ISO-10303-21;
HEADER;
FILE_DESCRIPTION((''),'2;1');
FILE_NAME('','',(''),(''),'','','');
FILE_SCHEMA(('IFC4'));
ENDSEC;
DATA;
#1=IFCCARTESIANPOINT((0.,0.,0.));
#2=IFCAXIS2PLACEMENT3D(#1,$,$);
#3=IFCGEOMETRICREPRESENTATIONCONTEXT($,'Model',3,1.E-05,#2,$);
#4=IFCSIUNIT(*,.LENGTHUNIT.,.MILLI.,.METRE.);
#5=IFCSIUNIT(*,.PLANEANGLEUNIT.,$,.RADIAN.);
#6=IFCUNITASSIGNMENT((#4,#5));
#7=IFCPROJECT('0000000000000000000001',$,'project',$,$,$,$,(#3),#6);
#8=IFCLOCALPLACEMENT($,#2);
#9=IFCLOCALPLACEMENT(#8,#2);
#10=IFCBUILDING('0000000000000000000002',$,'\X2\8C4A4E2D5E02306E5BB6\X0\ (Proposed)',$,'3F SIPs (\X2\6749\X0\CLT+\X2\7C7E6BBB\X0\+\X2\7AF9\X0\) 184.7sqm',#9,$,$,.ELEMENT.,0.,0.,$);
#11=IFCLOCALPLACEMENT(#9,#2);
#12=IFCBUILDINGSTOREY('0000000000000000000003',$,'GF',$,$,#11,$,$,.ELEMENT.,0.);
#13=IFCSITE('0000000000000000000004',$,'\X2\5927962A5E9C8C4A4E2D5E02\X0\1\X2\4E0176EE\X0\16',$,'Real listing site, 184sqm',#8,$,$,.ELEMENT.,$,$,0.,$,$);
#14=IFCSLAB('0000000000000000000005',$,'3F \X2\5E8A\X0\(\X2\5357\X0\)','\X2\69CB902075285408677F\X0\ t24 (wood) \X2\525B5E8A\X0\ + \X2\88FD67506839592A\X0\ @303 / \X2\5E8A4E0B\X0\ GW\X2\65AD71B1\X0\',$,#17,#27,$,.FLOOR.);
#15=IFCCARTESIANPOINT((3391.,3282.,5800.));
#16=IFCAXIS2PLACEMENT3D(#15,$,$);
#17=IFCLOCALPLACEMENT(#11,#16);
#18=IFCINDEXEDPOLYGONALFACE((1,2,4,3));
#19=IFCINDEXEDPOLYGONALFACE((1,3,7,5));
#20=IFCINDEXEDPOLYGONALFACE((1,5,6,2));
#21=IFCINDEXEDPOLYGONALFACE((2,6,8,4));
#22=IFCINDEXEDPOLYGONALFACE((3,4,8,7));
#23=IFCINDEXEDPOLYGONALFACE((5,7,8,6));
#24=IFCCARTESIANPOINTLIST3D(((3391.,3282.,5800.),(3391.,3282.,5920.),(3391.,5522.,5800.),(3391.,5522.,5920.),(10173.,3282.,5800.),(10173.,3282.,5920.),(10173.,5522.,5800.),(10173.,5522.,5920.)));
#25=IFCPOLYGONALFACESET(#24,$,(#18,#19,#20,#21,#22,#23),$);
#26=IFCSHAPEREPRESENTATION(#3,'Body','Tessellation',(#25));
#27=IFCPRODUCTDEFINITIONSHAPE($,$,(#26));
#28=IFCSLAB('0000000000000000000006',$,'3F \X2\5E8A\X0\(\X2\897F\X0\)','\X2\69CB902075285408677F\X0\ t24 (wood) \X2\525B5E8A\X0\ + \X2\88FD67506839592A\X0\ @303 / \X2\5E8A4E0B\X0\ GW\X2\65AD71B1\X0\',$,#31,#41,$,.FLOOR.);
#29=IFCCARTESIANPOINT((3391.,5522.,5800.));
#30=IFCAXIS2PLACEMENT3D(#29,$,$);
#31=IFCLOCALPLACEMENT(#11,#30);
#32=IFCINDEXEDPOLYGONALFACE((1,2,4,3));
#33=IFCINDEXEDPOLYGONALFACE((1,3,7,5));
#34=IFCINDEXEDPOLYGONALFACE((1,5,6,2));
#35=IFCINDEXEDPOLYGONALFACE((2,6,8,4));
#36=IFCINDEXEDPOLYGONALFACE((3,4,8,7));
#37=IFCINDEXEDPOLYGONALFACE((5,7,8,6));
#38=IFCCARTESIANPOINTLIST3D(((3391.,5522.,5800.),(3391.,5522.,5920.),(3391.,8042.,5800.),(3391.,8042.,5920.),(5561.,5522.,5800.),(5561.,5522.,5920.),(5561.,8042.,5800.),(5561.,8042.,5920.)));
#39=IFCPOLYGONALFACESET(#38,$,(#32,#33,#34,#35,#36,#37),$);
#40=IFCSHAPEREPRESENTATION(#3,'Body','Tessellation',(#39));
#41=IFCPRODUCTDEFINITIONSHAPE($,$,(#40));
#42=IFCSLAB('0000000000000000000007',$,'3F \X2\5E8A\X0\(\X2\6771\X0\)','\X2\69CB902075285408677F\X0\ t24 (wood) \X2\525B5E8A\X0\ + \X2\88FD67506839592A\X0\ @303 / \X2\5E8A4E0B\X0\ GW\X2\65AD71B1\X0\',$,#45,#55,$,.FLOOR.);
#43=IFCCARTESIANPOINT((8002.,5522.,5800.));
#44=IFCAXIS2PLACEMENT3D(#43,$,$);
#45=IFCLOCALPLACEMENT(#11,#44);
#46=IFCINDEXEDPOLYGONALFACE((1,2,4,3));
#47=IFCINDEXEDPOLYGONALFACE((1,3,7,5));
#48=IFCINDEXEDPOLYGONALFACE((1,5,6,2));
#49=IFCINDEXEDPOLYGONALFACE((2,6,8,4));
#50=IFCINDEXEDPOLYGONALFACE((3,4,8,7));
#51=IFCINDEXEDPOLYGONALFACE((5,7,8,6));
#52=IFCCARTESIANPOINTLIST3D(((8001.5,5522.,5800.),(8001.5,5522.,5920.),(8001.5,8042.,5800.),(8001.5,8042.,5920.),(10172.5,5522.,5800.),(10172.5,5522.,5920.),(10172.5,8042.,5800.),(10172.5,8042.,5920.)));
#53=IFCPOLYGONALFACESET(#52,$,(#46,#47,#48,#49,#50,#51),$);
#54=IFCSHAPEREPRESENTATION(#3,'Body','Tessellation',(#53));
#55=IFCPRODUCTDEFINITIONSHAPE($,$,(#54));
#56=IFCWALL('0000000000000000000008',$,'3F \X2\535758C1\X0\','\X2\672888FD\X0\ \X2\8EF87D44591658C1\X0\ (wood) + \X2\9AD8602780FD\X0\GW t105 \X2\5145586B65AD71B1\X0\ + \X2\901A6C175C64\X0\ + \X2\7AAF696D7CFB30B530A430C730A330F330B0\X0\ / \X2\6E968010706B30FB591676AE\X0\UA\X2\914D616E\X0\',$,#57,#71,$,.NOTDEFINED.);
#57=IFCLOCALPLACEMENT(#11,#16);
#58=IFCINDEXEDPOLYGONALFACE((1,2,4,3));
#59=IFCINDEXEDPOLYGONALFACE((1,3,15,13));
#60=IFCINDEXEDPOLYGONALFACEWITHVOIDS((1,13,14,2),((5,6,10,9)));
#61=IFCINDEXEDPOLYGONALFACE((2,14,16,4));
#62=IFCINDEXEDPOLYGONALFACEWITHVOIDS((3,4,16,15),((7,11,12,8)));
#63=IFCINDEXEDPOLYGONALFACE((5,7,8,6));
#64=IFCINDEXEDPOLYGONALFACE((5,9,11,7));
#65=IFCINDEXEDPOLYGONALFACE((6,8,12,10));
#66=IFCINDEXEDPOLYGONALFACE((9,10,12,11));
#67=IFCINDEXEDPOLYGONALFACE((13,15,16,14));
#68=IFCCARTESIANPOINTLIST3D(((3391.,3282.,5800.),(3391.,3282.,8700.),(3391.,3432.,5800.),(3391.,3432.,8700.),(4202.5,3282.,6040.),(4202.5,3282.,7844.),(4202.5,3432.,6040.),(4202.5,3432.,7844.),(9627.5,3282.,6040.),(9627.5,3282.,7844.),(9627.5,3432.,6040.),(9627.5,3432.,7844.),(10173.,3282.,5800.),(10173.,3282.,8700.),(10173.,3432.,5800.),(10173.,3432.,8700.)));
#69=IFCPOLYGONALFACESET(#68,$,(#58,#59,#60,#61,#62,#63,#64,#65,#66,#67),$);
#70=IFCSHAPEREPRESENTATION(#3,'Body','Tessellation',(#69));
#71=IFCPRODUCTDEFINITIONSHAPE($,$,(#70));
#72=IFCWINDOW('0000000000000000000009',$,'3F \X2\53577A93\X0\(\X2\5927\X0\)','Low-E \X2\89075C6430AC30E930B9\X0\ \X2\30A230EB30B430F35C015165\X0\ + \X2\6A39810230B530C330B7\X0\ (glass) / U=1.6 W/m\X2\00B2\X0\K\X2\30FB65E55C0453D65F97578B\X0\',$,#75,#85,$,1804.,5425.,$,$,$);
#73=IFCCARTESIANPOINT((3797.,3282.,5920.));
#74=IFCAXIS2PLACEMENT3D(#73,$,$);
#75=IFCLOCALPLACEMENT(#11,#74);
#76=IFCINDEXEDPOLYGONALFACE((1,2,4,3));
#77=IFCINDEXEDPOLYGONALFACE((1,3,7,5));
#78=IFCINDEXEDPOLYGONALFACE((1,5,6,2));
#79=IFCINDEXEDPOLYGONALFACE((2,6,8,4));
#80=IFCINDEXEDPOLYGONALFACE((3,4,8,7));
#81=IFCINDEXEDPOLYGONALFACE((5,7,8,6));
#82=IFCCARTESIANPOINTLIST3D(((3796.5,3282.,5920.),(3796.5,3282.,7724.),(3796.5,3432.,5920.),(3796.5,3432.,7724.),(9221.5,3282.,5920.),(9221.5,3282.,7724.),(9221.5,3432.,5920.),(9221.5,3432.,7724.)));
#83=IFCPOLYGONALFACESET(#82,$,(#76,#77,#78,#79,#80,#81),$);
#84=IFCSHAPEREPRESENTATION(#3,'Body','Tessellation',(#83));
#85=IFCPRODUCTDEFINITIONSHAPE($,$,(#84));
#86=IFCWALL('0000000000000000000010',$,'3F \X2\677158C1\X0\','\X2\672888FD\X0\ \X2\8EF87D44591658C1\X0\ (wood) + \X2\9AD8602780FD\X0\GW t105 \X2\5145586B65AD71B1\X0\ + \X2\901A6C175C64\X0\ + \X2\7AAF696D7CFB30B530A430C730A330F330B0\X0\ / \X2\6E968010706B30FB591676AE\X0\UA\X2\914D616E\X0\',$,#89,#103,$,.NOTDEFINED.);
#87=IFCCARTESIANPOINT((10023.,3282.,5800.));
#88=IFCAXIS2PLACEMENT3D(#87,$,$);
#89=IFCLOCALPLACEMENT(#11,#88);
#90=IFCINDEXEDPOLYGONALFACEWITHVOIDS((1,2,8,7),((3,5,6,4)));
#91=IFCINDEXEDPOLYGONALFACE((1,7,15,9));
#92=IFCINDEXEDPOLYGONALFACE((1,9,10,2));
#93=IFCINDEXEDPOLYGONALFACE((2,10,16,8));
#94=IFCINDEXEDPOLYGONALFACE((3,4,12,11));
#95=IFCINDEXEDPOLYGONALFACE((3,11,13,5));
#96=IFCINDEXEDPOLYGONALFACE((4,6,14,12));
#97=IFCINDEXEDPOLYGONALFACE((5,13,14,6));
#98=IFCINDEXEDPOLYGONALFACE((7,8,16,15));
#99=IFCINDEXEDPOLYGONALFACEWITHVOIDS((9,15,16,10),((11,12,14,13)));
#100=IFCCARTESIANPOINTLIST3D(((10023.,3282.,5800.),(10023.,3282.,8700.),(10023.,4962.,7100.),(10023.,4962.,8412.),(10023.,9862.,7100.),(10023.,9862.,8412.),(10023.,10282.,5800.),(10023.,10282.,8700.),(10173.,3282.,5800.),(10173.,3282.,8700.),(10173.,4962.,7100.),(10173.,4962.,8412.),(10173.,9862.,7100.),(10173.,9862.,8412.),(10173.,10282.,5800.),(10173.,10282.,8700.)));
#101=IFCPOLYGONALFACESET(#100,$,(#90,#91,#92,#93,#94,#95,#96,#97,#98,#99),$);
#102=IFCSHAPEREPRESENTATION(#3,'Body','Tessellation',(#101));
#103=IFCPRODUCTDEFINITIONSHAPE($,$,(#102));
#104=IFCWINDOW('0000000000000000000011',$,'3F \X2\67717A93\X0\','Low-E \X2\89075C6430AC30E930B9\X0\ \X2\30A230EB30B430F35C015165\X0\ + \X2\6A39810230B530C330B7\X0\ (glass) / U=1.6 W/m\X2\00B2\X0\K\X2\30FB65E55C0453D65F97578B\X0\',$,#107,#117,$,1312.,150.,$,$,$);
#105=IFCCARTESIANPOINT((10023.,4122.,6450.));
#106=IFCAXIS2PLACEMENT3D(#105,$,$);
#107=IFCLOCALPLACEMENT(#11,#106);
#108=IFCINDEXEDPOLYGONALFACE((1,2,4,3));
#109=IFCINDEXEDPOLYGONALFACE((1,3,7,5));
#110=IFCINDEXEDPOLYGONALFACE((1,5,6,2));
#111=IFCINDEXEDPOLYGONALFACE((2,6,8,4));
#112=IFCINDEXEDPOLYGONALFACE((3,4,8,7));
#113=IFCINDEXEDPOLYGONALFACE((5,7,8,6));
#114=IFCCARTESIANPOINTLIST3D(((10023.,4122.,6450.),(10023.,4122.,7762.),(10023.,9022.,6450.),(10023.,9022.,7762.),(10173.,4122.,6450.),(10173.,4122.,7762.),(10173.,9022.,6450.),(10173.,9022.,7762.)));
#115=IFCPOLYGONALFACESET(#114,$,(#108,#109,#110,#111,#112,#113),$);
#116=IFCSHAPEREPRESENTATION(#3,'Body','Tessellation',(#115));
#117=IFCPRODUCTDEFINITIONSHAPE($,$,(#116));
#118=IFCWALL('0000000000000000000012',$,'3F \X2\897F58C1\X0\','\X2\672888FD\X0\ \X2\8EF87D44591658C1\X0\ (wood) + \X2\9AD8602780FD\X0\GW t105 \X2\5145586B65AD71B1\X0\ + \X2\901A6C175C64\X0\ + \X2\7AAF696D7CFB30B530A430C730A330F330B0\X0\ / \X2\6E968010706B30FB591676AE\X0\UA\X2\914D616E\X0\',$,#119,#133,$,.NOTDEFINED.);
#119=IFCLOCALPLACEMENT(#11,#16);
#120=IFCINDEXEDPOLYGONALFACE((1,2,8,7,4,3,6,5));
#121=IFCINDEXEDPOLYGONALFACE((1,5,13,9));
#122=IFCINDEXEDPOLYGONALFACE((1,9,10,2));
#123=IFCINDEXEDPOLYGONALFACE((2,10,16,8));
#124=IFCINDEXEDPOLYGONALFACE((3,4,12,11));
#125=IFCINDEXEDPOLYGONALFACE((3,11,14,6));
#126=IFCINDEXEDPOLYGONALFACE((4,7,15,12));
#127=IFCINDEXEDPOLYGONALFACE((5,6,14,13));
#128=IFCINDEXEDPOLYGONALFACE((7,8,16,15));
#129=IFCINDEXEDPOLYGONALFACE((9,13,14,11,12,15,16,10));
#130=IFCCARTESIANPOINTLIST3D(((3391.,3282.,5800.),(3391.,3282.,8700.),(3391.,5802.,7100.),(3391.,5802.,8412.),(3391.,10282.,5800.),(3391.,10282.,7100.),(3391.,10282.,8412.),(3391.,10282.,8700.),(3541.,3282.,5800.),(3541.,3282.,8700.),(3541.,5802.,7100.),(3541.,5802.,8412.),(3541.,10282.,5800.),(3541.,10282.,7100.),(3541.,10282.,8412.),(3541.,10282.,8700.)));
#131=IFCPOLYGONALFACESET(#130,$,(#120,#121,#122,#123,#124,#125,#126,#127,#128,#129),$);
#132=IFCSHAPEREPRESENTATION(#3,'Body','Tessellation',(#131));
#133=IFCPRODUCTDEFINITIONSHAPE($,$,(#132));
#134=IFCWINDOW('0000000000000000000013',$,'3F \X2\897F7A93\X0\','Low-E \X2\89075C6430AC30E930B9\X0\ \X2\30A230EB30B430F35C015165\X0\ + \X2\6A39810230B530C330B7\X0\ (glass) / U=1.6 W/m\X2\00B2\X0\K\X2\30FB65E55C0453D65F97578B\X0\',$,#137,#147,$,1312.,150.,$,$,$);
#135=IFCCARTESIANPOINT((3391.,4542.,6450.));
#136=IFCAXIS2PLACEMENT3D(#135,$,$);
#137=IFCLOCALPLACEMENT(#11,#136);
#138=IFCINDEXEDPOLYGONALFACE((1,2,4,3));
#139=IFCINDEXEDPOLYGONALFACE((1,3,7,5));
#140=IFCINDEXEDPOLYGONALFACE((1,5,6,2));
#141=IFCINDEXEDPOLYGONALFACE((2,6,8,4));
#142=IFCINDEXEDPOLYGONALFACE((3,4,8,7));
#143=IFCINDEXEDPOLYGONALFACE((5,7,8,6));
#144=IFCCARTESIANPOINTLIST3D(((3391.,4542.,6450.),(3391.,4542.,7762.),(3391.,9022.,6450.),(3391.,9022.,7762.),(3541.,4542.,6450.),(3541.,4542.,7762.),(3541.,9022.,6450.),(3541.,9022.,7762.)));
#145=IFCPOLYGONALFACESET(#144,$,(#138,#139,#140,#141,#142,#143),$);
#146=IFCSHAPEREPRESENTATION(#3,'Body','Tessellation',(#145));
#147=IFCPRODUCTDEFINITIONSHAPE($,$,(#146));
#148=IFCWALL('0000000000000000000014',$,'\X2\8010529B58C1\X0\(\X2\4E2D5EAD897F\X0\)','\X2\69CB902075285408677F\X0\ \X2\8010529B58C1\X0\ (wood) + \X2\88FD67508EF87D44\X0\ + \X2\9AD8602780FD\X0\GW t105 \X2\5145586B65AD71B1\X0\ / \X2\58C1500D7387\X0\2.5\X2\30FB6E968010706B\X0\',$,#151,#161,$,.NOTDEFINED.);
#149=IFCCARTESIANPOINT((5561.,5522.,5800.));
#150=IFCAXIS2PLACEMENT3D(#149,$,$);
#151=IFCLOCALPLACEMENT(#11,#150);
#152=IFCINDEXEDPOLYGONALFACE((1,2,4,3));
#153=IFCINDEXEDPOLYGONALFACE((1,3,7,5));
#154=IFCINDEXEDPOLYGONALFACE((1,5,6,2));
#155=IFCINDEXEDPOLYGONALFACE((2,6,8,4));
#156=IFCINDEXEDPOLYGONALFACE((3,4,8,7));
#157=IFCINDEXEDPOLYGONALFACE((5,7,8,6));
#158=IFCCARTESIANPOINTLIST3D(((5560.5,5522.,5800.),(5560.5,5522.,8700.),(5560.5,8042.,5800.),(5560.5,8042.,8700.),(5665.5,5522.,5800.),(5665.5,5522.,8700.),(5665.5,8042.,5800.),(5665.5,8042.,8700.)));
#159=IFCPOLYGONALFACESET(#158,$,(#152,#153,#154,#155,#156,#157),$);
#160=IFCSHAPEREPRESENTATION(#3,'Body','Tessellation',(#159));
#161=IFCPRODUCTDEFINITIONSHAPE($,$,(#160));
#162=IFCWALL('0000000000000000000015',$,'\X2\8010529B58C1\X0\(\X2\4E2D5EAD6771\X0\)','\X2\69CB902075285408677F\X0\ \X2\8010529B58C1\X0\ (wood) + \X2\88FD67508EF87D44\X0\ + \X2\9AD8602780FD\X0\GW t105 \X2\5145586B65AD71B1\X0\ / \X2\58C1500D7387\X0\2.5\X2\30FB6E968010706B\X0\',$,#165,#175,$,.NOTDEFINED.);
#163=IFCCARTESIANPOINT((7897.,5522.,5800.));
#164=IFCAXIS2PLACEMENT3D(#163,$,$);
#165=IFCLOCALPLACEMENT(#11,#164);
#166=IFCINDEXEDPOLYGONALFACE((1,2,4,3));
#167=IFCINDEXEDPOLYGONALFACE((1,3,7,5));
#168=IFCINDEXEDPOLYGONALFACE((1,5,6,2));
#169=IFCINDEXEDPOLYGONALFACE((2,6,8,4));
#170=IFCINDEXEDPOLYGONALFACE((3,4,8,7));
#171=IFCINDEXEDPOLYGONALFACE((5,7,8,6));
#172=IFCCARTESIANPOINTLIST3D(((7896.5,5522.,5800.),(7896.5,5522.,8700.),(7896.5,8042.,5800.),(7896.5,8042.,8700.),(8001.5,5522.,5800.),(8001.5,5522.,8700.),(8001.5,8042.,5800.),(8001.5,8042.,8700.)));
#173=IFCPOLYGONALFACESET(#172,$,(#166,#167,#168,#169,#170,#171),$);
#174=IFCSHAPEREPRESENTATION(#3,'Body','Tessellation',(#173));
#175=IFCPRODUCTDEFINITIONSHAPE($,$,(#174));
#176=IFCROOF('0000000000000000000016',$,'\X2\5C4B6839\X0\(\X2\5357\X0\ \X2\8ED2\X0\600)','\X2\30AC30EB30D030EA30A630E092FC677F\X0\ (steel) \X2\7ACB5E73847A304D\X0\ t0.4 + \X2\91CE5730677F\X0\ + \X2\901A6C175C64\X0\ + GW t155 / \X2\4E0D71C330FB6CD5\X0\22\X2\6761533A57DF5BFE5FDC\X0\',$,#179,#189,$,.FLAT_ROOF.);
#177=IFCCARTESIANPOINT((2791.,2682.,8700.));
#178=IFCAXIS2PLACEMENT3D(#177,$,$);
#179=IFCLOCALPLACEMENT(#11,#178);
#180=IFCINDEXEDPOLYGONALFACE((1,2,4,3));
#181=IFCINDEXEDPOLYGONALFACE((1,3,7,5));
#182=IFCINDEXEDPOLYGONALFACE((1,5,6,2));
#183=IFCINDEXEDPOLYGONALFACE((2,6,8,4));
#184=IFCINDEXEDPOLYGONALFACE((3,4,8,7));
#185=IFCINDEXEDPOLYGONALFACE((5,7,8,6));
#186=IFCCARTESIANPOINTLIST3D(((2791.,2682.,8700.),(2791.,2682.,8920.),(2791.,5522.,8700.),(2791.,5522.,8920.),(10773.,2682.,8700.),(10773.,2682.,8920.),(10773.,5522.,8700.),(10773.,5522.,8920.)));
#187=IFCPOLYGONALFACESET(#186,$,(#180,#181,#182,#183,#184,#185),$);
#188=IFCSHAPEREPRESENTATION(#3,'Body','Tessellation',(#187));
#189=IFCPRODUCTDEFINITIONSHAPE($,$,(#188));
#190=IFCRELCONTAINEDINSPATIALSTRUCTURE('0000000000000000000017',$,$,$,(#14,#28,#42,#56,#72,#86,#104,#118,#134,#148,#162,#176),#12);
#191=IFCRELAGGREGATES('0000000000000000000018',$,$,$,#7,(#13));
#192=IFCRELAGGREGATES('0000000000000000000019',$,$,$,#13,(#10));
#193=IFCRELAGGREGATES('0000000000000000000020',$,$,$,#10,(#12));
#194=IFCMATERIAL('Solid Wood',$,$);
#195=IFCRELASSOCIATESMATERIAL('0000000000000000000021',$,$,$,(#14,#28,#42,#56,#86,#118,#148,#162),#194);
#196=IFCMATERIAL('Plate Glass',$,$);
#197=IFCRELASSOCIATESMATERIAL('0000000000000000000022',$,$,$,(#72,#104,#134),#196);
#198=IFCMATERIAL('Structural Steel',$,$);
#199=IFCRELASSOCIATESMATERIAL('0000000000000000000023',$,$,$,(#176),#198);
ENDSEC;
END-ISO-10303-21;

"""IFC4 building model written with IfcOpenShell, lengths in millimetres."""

from ifc_helpers import new_model, si_unit, frame, frame_2d, origin, place, context, project, spatial, rectangle, extrude, material, element, fill, save


model = new_model("IFC4")

# Units and contexts
model_context = context("Model", 3, precision=1e-05, world=origin())
ifc_project = project(units=[si_unit("LENGTHUNIT", "METRE", prefix="MILLI"), si_unit("PLANEANGLEUNIT", "RADIAN")], contexts=[model_context])

# Site, building, storey
site_placement = place(None, origin())
site = spatial("IfcSite", under=ifc_project, at=site_placement, Name="大阪府豊中市1丁目16", ObjectType="Real listing site, 184sqm", CompositionType="ELEMENT", RefElevation=0.0)
building_placement = place(site_placement, origin())
building = spatial("IfcBuilding", under=site, at=building_placement, Name="豊中市の家 (Proposed)", ObjectType="3F SIPs (杉CLT+籾殻+竹) 184.7sqm", CompositionType="ELEMENT", ElevationOfRefHeight=0.0, ElevationOfTerrain=0.0)
storey_placement = place(building_placement, origin())
storey = spatial("IfcBuildingStorey", under=building, at=storey_placement, Name="GF", CompositionType="ELEMENT", Elevation=0.0)

# Slabs
ifc_material_1 = material(Name="Solid Wood")
slab_1_placement = place(storey_placement, frame((3391.0, 3282.0, 5800.0)))
element("IfcSlab", 1, at=slab_1_placement, inside=storey, material=ifc_material_1, Name="3F 床(南)", Description="構造用合板 t24 (wood) 剛床 + 製材根太 @303 / 床下 GW断熱", PredefinedType="FLOOR", context=model_context, shape_type="SweptSolid", body=[
    extrude(rectangle(XDim=6782.0, YDim=2240.0, at=frame_2d((3391.0, 1120.0))), frame((3391.0, 3282.0, 5800.0)), (0.0, 0.0, 1.0), 120.0),
])
slab_2_placement = place(storey_placement, frame((3391.0, 5522.0, 5800.0)))
element("IfcSlab", 2, at=slab_2_placement, inside=storey, material=ifc_material_1, Name="3F 床(西)", Description="構造用合板 t24 (wood) 剛床 + 製材根太 @303 / 床下 GW断熱", PredefinedType="FLOOR", context=model_context, shape_type="SweptSolid", body=[
    extrude(rectangle(XDim=2170.0, YDim=2520.0, at=frame_2d((1085.0, 1260.0))), frame((3391.0, 5522.0, 5800.0)), (0.0, 0.0, 1.0), 120.0),
])
slab_3_placement = place(storey_placement, frame((8002.0, 5522.0, 5800.0)))
element("IfcSlab", 3, at=slab_3_placement, inside=storey, material=ifc_material_1, Name="3F 床(東)", Description="構造用合板 t24 (wood) 剛床 + 製材根太 @303 / 床下 GW断熱", PredefinedType="FLOOR", context=model_context, shape_type="SweptSolid", body=[
    extrude(rectangle(XDim=2171.0, YDim=2520.0, at=frame_2d((1085.0, 1260.0))), frame((8002.0, 5522.0, 5800.0)), (0.0, 0.0, 1.0), 120.0),
])

# Walls, openings, windows
wall_1_placement = place(storey_placement, frame((3391.0, 3282.0, 5800.0)))
wall_1 = element("IfcWall", 4, at=wall_1_placement, inside=storey, material=ifc_material_1, Name="3F 南壁", Description="木製 軸組外壁 (wood) + 高性能GW t105 充填断熱 + 通気層 + 窯業系サイディング / 準耐火・外皮UA配慮", PredefinedType="NOTDEFINED", context=model_context, shape_type="SweptSolid", body=[
    extrude(rectangle(XDim=6782.0, YDim=150.0, at=frame_2d((3391.0, 75.0))), frame((3391.0, 3282.0, 5800.0)), (0.0, 0.0, 1.0), 2900.0),
])
opening_1_placement = place(storey_placement, frame((3797.0, 3282.0, 5920.0)))
opening_1 = element("IfcOpeningElement", 5, at=opening_1_placement, cuts=wall_1, PredefinedType="NOTDEFINED", context=model_context, shape_type="SweptSolid", body=[
    extrude(rectangle(XDim=5425.0, YDim=150.0, at=frame_2d((2712.0, 75.0))), frame((3797.0, 3282.0, 5920.0)), (0.0, 0.0, 1.0), 1804.0),
])
ifc_material_2 = material(Name="Plate Glass")
window_1_placement = place(storey_placement, frame((3797.0, 3282.0, 5920.0)))
window_1 = element("IfcWindow", 6, at=window_1_placement, inside=storey, material=ifc_material_2, Name="3F 南窓(大)", Description="Low-E 複層ガラス アルゴン封入 + 樹脂サッシ (glass) / U=1.6 W/m²K・日射取得型", OverallHeight=1804.0, OverallWidth=5425.0, context=model_context, shape_type="SweptSolid", body=[
    extrude(rectangle(XDim=5425.0, YDim=150.0, at=frame_2d((2712.0, 75.0))), frame((3797.0, 3282.0, 5920.0)), (0.0, 0.0, 1.0), 1804.0),
])
fill(opening_1, window_1)
wall_2_placement = place(storey_placement, frame((10023.0, 3282.0, 5800.0)))
wall_2 = element("IfcWall", 7, at=wall_2_placement, inside=storey, material=ifc_material_1, Name="3F 東壁", Description="木製 軸組外壁 (wood) + 高性能GW t105 充填断熱 + 通気層 + 窯業系サイディング / 準耐火・外皮UA配慮", PredefinedType="NOTDEFINED", context=model_context, shape_type="SweptSolid", body=[
    extrude(rectangle(XDim=150.0, YDim=7000.0, at=frame_2d((75.0, 3500.0))), frame((10023.0, 3282.0, 5800.0)), (0.0, 0.0, 1.0), 2900.0),
])
opening_2_placement = place(storey_placement, frame((10023.0, 4122.0, 6450.0)))
opening_2 = element("IfcOpeningElement", 8, at=opening_2_placement, cuts=wall_2, PredefinedType="NOTDEFINED", context=model_context, shape_type="SweptSolid", body=[
    extrude(rectangle(XDim=150.0, YDim=4900.0, at=frame_2d((75.0, 2450.0))), frame((10023.0, 4122.0, 6450.0)), (0.0, 0.0, 1.0), 1312.0),
])
window_2_placement = place(storey_placement, frame((10023.0, 4122.0, 6450.0)))
window_2 = element("IfcWindow", 9, at=window_2_placement, inside=storey, material=ifc_material_2, Name="3F 東窓", Description="Low-E 複層ガラス アルゴン封入 + 樹脂サッシ (glass) / U=1.6 W/m²K・日射取得型", OverallHeight=1312.0, OverallWidth=150.0, context=model_context, shape_type="SweptSolid", body=[
    extrude(rectangle(XDim=150.0, YDim=4900.0, at=frame_2d((75.0, 2450.0))), frame((10023.0, 4122.0, 6450.0)), (0.0, 0.0, 1.0), 1312.0),
])
fill(opening_2, window_2)
wall_3_placement = place(storey_placement, frame((3391.0, 3282.0, 5800.0)))
wall_3 = element("IfcWall", 10, at=wall_3_placement, inside=storey, material=ifc_material_1, Name="3F 西壁", Description="木製 軸組外壁 (wood) + 高性能GW t105 充填断熱 + 通気層 + 窯業系サイディング / 準耐火・外皮UA配慮", PredefinedType="NOTDEFINED", context=model_context, shape_type="SweptSolid", body=[
    extrude(rectangle(XDim=150.0, YDim=7000.0, at=frame_2d((75.0, 3500.0))), frame((3391.0, 3282.0, 5800.0)), (0.0, 0.0, 1.0), 2900.0),
])
opening_3_placement = place(storey_placement, frame((3391.0, 4542.0, 6450.0)))
opening_3 = element("IfcOpeningElement", 11, at=opening_3_placement, cuts=wall_3, PredefinedType="NOTDEFINED", context=model_context, shape_type="SweptSolid", body=[
    extrude(rectangle(XDim=150.0, YDim=4480.0, at=frame_2d((75.0, 2240.0))), frame((3391.0, 4542.0, 6450.0)), (0.0, 0.0, 1.0), 1312.0),
])
window_3_placement = place(storey_placement, frame((3391.0, 4542.0, 6450.0)))
window_3 = element("IfcWindow", 12, at=window_3_placement, inside=storey, material=ifc_material_2, Name="3F 西窓", Description="Low-E 複層ガラス アルゴン封入 + 樹脂サッシ (glass) / U=1.6 W/m²K・日射取得型", OverallHeight=1312.0, OverallWidth=150.0, context=model_context, shape_type="SweptSolid", body=[
    extrude(rectangle(XDim=150.0, YDim=4480.0, at=frame_2d((75.0, 2240.0))), frame((3391.0, 4542.0, 6450.0)), (0.0, 0.0, 1.0), 1312.0),
])
fill(opening_3, window_3)

# Walls
wall_4_placement = place(storey_placement, frame((5561.0, 5522.0, 5800.0)))
element("IfcWall", 13, at=wall_4_placement, inside=storey, material=ifc_material_1, Name="耐力壁(中庭西)", Description="構造用合板 耐力壁 (wood) + 製材軸組 + 高性能GW t105 充填断熱 / 壁倍率2.5・準耐火", PredefinedType="NOTDEFINED", context=model_context, shape_type="SweptSolid", body=[
    extrude(rectangle(XDim=105.0, YDim=2520.0, at=frame_2d((52.0, 1260.0))), frame((5561.0, 5522.0, 5800.0)), (0.0, 0.0, 1.0), 2900.0),
])
wall_5_placement = place(storey_placement, frame((7897.0, 5522.0, 5800.0)))
element("IfcWall", 14, at=wall_5_placement, inside=storey, material=ifc_material_1, Name="耐力壁(中庭東)", Description="構造用合板 耐力壁 (wood) + 製材軸組 + 高性能GW t105 充填断熱 / 壁倍率2.5・準耐火", PredefinedType="NOTDEFINED", context=model_context, shape_type="SweptSolid", body=[
    extrude(rectangle(XDim=105.0, YDim=2520.0, at=frame_2d((52.0, 1260.0))), frame((7897.0, 5522.0, 5800.0)), (0.0, 0.0, 1.0), 2900.0),
])

# Roof
ifc_material_3 = material(Name="Structural Steel")
roof_1_placement = place(storey_placement, frame((2791.0, 2682.0, 8700.0)))
element("IfcRoof", 15, at=roof_1_placement, inside=storey, material=ifc_material_3, Name="屋根(南 軒600)", Description="ガルバリウム鋼板 (steel) 立平葺き t0.4 + 野地板 + 通気層 + GW t155 / 不燃・法22条区域対応", PredefinedType="FLAT_ROOF", context=model_context, shape_type="SweptSolid", body=[
    extrude(rectangle(XDim=7982.0, YDim=2840.0, at=frame_2d((3991.0, 1420.0))), frame((2791.0, 2682.0, 8700.0)), (0.0, 0.0, 1.0), 220.0),
])

save(model, "model.ifc")
